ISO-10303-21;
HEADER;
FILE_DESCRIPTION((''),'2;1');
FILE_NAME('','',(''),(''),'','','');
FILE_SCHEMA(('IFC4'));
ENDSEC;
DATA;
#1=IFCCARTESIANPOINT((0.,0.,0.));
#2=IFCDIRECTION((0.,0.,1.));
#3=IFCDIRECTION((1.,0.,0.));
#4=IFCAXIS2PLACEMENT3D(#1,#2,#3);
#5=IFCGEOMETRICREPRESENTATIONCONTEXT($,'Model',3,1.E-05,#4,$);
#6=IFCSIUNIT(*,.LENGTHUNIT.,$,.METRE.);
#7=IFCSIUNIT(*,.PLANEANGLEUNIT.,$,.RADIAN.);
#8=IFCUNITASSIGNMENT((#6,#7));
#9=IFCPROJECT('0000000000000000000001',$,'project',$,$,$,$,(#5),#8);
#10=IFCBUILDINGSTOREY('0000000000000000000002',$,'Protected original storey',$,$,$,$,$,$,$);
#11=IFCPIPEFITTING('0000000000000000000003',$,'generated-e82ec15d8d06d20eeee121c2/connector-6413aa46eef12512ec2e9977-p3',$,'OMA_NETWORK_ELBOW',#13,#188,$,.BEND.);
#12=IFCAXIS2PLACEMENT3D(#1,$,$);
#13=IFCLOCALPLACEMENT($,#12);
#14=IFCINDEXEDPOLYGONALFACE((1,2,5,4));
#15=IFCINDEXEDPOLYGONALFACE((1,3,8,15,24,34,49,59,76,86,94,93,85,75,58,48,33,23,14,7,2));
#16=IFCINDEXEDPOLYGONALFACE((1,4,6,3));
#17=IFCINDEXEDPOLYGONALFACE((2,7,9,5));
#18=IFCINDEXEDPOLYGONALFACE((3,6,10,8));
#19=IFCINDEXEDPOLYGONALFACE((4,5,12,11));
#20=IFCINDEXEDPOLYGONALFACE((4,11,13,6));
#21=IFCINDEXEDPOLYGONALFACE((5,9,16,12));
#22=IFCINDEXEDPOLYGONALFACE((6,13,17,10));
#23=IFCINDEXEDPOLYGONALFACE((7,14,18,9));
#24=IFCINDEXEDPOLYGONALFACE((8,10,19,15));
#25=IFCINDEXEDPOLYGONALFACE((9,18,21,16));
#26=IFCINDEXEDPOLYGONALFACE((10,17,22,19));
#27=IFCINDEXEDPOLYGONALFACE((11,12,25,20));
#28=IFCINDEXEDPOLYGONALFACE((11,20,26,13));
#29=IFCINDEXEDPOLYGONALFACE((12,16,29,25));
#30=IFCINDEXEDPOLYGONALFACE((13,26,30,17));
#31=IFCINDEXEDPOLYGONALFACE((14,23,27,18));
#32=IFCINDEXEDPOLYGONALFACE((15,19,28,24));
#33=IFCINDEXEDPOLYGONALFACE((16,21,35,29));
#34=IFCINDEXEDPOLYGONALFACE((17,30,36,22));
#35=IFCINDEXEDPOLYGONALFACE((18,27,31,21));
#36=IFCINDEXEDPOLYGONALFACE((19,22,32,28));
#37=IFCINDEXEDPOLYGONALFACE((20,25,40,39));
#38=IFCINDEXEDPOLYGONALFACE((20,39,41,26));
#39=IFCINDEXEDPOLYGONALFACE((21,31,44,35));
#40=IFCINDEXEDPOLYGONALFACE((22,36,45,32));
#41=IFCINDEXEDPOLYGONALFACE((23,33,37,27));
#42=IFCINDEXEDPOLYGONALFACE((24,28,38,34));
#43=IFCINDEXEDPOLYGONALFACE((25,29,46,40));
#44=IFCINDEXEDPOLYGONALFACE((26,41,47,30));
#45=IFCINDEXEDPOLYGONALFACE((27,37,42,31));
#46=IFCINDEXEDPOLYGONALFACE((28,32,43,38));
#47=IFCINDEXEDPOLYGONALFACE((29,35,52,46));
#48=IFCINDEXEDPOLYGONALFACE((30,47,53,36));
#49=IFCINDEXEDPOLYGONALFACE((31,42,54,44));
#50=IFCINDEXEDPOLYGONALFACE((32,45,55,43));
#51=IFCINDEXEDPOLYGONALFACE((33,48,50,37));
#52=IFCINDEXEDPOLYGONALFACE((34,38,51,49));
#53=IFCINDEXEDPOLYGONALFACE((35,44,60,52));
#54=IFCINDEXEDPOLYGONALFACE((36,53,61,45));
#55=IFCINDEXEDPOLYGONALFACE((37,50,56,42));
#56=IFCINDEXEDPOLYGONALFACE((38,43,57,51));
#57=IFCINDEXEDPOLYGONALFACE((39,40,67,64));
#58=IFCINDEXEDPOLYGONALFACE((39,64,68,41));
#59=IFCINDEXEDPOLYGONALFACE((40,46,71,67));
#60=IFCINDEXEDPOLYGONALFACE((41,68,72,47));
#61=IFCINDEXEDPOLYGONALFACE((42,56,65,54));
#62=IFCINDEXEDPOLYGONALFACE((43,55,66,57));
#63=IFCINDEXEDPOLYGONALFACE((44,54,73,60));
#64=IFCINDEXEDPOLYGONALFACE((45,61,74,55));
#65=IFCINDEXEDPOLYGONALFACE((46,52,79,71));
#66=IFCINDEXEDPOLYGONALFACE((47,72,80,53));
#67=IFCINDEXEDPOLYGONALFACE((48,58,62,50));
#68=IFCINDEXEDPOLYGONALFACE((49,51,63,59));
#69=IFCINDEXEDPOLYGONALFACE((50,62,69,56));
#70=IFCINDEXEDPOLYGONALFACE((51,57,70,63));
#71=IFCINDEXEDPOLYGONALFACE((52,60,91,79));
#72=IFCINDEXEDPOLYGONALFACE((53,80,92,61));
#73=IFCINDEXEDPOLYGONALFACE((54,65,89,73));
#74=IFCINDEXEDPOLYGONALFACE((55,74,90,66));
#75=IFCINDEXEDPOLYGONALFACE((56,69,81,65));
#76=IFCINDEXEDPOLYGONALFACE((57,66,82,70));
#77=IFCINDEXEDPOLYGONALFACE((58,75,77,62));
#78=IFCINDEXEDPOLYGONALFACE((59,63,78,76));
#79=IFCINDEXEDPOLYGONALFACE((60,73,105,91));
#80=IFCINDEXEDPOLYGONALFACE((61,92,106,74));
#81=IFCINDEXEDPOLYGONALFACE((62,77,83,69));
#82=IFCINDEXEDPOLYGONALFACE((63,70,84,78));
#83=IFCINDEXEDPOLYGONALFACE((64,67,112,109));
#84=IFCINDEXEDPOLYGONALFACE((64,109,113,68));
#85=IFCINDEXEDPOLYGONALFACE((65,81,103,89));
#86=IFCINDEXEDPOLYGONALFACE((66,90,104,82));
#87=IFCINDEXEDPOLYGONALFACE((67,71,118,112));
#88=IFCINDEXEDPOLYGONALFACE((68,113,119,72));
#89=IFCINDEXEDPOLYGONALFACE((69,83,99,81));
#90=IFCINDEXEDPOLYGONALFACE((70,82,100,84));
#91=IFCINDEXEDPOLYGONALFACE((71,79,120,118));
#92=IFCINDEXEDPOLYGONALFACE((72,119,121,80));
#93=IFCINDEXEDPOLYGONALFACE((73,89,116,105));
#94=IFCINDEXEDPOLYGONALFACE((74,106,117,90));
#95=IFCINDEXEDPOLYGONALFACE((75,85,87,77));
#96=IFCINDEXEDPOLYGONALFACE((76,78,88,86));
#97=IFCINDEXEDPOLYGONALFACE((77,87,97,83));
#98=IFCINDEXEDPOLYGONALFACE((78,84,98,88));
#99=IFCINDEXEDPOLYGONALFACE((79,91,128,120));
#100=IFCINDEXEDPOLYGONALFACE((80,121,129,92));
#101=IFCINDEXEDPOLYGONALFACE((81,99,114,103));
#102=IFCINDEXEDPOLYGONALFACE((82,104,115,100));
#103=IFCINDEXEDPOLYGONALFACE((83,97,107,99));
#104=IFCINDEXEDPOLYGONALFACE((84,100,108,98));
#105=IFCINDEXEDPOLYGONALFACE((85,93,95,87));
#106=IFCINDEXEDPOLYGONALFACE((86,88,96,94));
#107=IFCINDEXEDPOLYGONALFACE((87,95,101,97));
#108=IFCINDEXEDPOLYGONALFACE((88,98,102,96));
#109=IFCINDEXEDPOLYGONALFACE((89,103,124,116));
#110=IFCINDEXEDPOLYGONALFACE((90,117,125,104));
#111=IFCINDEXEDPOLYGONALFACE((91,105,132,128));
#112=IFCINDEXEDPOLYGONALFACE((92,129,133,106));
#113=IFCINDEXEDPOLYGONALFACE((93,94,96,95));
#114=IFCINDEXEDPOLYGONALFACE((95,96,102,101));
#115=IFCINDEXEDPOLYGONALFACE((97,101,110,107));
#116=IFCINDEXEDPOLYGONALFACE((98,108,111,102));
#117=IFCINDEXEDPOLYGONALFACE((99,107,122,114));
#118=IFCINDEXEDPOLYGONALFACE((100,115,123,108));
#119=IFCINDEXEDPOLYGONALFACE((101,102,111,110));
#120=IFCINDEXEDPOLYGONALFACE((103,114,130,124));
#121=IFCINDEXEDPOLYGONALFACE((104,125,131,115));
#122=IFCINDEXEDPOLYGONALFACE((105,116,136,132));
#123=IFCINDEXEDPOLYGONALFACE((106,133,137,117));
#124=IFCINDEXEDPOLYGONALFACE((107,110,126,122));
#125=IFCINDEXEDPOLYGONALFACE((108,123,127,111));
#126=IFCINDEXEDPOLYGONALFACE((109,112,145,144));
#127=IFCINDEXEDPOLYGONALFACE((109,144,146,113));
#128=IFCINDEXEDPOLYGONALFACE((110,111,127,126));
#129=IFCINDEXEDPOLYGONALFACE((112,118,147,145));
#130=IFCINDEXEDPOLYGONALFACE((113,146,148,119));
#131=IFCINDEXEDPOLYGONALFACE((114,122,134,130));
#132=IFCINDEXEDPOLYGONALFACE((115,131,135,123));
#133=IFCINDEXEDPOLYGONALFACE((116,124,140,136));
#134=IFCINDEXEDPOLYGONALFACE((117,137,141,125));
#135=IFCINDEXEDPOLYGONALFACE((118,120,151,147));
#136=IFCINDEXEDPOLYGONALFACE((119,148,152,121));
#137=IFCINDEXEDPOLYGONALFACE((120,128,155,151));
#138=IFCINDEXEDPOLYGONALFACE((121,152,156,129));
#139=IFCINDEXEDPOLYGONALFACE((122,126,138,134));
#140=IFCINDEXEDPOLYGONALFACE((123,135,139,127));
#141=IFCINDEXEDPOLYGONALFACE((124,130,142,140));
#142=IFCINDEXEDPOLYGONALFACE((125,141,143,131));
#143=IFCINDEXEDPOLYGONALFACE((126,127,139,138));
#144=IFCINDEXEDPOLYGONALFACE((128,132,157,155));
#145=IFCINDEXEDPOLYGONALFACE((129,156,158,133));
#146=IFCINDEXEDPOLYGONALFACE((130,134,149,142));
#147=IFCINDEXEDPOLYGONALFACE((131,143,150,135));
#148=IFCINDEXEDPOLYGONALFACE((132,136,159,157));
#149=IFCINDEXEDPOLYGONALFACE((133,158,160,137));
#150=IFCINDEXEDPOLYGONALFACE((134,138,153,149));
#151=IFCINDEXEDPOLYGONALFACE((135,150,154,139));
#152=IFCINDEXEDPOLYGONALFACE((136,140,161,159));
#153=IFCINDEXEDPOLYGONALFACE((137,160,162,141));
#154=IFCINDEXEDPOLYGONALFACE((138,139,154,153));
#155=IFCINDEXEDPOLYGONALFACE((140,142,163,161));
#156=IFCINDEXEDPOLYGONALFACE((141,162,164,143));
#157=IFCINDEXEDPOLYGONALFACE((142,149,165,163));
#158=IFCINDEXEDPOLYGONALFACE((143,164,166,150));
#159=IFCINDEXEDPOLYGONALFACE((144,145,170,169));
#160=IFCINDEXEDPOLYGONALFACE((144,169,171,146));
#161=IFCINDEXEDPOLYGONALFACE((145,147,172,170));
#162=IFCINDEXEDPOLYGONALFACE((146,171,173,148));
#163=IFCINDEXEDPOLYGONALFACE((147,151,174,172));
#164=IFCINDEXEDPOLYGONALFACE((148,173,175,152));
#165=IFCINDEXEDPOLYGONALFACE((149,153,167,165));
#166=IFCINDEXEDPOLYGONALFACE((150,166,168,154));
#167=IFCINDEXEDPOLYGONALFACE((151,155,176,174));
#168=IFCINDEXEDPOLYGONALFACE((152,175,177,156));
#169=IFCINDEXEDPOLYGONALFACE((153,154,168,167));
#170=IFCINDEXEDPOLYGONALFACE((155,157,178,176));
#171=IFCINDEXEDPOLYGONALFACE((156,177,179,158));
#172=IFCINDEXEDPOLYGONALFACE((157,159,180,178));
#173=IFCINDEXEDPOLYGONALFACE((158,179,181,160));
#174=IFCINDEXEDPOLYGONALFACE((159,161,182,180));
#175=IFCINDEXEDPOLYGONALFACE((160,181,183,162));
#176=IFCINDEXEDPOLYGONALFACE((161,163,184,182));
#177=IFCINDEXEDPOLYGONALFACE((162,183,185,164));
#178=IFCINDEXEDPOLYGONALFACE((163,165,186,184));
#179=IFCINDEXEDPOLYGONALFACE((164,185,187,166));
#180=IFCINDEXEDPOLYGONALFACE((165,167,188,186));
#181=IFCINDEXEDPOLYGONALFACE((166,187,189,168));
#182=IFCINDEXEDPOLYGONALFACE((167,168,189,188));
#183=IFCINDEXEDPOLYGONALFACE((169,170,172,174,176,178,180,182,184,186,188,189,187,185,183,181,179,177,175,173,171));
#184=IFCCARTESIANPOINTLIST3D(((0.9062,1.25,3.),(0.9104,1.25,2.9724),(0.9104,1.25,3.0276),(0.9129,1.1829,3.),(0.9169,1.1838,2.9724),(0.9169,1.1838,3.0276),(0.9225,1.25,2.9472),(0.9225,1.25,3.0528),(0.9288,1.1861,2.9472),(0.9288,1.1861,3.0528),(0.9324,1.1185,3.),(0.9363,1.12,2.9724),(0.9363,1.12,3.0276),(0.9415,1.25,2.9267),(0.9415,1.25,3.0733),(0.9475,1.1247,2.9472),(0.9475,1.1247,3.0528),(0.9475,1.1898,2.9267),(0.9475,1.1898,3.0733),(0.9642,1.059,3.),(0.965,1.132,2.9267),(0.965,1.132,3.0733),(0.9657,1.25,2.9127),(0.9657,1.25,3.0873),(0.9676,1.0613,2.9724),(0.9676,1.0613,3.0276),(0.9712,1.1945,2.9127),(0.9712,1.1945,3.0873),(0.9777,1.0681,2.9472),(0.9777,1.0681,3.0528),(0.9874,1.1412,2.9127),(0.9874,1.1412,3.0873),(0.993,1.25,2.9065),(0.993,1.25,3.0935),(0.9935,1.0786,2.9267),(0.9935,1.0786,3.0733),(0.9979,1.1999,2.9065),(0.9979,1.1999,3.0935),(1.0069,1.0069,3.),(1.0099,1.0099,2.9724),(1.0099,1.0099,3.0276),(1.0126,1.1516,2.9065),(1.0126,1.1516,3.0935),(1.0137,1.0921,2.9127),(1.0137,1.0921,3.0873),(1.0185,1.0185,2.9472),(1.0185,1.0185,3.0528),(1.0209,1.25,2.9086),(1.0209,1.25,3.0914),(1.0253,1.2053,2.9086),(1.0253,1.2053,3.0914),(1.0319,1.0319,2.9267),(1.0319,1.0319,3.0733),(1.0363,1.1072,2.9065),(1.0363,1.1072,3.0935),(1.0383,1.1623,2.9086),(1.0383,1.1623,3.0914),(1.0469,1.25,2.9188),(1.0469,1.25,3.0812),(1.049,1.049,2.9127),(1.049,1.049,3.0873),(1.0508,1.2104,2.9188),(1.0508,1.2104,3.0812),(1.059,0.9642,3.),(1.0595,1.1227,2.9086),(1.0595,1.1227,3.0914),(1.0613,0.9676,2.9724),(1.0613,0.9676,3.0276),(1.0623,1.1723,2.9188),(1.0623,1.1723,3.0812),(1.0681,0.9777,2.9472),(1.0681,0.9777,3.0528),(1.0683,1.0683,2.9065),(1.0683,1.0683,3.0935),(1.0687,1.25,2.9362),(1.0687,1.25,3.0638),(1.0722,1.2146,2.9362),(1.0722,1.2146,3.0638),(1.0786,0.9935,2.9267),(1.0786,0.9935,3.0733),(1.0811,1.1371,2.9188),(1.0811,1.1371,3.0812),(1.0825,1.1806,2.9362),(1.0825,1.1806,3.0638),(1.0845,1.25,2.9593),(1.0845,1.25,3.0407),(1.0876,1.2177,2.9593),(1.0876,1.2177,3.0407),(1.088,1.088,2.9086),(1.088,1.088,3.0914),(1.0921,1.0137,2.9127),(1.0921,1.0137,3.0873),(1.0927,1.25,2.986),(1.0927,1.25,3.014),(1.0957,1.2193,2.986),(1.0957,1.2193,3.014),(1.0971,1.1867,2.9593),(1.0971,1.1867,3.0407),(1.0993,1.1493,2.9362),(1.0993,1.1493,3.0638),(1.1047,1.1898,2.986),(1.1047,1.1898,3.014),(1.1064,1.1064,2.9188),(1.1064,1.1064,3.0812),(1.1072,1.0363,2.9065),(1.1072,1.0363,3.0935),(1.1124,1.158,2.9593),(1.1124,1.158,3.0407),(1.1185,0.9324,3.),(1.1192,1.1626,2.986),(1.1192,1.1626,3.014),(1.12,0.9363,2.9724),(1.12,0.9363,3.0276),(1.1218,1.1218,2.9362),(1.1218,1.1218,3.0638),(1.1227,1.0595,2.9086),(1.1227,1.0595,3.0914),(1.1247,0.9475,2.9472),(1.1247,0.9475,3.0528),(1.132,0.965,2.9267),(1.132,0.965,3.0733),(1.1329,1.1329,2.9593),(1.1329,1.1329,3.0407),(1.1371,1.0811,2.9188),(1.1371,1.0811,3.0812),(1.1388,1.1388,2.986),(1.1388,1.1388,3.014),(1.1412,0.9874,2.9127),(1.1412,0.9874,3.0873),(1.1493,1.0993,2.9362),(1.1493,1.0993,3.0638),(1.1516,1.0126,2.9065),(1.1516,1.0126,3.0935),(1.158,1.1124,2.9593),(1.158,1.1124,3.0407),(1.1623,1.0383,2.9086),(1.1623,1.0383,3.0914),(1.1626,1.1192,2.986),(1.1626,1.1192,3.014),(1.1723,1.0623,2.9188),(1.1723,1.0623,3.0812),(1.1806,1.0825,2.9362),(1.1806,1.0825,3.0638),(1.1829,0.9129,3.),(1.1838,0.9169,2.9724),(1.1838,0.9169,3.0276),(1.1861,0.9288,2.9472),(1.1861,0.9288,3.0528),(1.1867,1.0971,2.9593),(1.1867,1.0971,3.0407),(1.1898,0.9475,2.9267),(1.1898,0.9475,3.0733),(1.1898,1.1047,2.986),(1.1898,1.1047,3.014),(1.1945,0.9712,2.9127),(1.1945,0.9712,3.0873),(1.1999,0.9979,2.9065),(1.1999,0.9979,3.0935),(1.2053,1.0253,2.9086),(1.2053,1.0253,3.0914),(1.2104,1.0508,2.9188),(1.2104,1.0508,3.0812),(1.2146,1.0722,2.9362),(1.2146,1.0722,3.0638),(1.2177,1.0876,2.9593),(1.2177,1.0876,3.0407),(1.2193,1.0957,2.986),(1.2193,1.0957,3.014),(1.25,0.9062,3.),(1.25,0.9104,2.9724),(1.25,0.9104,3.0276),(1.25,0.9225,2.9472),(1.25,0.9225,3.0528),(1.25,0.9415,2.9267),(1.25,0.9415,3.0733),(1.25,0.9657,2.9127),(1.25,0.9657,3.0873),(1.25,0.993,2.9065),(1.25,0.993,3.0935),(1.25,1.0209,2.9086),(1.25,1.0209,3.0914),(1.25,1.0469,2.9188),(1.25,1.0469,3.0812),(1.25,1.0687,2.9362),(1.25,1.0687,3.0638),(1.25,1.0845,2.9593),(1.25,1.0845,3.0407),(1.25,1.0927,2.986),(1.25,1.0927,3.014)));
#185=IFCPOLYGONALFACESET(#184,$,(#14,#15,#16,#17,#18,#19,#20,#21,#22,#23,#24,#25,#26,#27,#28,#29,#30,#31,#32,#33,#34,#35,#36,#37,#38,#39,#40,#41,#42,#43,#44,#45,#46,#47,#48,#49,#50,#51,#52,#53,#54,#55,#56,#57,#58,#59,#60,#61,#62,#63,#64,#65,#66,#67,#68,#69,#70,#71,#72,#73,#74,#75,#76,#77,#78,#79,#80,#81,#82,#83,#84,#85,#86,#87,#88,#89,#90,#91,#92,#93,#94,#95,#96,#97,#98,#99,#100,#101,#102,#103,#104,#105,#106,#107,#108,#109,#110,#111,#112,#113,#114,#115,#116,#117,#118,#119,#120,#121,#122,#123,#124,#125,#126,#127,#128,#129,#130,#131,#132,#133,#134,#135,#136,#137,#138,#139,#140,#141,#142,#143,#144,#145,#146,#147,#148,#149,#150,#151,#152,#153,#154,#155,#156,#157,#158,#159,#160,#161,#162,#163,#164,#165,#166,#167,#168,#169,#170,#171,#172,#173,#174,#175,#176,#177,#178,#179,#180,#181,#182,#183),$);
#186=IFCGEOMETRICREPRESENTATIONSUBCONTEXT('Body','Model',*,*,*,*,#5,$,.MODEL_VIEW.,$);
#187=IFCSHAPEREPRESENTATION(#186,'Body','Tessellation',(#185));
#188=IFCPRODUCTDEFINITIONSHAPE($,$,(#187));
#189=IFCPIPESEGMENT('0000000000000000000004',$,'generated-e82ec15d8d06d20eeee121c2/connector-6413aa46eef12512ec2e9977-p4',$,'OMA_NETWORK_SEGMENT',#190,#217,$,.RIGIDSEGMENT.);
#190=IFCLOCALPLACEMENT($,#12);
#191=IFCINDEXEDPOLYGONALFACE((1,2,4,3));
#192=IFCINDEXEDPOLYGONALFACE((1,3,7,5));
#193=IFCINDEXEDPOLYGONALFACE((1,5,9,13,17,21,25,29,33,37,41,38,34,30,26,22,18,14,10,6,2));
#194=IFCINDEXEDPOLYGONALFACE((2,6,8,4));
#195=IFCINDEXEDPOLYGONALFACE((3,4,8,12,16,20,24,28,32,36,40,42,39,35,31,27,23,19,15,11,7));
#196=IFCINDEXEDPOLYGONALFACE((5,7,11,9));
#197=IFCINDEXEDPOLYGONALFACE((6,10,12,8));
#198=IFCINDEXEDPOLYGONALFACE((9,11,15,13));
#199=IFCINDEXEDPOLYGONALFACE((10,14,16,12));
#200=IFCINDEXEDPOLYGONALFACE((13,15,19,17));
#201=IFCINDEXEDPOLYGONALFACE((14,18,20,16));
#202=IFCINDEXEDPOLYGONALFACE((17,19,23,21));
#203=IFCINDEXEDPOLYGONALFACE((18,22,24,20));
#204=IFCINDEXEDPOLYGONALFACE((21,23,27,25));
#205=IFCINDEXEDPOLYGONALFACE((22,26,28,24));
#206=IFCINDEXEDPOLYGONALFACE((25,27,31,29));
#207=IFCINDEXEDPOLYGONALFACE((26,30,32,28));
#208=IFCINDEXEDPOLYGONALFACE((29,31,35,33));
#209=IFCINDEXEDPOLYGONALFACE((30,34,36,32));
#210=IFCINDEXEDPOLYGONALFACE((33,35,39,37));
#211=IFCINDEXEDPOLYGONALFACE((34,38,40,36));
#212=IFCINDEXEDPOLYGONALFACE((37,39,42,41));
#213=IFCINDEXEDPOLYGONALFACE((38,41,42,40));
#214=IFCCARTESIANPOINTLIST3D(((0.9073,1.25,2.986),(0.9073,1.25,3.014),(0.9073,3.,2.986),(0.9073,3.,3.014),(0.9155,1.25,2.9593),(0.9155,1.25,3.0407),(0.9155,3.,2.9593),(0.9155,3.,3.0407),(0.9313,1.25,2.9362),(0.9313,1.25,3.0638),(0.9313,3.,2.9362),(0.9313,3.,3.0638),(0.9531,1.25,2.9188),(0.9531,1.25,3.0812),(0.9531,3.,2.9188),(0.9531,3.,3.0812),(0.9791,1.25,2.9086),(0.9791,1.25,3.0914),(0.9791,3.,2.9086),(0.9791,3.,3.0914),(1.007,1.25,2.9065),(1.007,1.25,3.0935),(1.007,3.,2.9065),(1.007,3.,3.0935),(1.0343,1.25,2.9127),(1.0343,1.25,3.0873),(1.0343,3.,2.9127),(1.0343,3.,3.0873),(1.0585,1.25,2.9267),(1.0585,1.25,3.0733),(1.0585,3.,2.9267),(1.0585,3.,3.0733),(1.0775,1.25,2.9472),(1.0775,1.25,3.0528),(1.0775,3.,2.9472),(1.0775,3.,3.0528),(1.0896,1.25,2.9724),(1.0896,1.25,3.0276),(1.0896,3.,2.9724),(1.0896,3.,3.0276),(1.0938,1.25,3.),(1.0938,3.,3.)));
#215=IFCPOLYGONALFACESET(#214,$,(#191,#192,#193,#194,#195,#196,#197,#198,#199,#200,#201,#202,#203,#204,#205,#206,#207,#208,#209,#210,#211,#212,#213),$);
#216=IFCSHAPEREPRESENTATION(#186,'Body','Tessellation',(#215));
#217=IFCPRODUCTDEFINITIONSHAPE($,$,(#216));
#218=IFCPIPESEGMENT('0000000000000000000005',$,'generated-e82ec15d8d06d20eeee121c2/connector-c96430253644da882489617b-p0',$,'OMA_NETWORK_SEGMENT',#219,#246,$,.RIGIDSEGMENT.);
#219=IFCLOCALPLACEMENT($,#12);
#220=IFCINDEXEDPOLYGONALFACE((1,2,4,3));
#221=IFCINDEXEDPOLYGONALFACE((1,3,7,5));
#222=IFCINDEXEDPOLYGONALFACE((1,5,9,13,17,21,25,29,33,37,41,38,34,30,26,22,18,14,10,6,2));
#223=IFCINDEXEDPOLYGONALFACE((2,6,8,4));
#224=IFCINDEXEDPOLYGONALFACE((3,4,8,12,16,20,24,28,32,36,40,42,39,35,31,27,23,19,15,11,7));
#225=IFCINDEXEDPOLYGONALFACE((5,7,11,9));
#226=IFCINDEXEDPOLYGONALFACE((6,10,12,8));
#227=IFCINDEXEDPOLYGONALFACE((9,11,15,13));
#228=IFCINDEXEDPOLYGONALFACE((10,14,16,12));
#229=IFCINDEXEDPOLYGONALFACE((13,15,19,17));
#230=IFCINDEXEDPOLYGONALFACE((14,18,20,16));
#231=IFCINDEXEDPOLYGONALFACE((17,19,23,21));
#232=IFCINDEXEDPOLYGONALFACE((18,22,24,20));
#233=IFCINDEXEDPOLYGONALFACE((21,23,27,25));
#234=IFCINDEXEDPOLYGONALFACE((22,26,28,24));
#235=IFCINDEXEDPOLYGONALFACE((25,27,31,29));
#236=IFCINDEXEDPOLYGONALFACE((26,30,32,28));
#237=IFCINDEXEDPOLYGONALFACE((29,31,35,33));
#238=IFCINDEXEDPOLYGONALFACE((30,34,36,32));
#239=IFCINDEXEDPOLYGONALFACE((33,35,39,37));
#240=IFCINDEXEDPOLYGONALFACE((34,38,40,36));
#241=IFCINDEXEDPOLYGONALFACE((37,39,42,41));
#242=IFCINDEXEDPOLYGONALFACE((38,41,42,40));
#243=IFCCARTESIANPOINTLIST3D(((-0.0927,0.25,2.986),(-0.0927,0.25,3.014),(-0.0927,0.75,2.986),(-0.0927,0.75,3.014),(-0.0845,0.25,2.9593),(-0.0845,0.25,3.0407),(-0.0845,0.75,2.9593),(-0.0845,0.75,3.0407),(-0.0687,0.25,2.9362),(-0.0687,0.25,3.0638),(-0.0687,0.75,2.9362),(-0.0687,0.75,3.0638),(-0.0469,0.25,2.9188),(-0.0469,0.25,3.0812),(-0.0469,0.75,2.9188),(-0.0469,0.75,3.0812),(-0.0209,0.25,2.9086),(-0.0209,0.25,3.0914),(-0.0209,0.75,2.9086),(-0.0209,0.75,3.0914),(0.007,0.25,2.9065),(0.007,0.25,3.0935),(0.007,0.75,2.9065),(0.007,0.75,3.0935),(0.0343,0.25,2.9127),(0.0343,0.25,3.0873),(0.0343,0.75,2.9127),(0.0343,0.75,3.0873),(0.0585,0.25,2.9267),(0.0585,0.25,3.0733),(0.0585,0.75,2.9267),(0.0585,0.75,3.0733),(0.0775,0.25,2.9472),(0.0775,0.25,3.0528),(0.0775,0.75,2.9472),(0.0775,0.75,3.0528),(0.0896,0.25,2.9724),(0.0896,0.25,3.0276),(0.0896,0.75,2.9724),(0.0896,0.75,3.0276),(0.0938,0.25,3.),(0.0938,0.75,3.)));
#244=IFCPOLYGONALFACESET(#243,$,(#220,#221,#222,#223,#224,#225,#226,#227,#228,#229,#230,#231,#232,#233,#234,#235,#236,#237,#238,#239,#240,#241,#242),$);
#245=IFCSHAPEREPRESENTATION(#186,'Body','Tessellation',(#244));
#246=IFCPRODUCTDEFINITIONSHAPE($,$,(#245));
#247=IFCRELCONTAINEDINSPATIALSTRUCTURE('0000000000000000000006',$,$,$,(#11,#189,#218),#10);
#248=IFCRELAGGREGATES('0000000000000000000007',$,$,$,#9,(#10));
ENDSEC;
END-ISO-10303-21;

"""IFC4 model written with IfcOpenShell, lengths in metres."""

from ifc_helpers import new_model, entity, si_unit, frame, origin_with_axes, origin_2d, place, context, subcontext, project, spatial, circle, extrude, element, save


model = new_model("IFC4")

# Units and contexts
model_context = context("Model", 3, precision=1e-05, world=origin_with_axes())
body_context = subcontext(model_context, "Body", "Model", "MODEL_VIEW")
ifc_project = project(units=[si_unit("LENGTHUNIT", "METRE"), si_unit("PLANEANGLEUNIT", "RADIAN")], contexts=[model_context])

# Storey
storey = spatial("IfcBuildingStorey", under=ifc_project, Name="Protected original storey")

# Pipe fitting
pipe_fitting_1_placement = place(None, origin_with_axes())
element("IfcPipeFitting", 1, at=pipe_fitting_1_placement, inside=storey, Name="generated-e82ec15d8d06d20eeee121c2/connector-6413aa46eef12512ec2e9977-p3", ObjectType="OMA_NETWORK_ELBOW", PredefinedType="BEND", context=body_context, shape_type="SweptSolid", body=[
    entity("IfcRevolvedAreaSolid", entity("IfcCircleProfileDef", "AREA", None, entity("IfcAxis2Placement2D", entity("IfcCartesianPoint", [0.25, 0.0])), 0.0938), entity("IfcAxis2Placement3D", entity("IfcCartesianPoint", [1.25, 1.25, 3.0]), entity("IfcDirection", [-1.0, 0.0, 0.0]), entity("IfcDirection", [0.0, -1.0, 0.0])), entity("IfcAxis1Placement", entity("IfcCartesianPoint", [0.0, 0.0, 0.0]), entity("IfcDirection", [0.0, -1.0, 0.0])), 1.570796),
])

# Pipe segments
pipe_segment_1_placement = place(None, origin_with_axes())
element("IfcPipeSegment", 2, at=pipe_segment_1_placement, inside=storey, Name="generated-e82ec15d8d06d20eeee121c2/connector-6413aa46eef12512ec2e9977-p4", ObjectType="OMA_NETWORK_SEGMENT", PredefinedType="RIGIDSEGMENT", context=body_context, shape_type="SweptSolid", body=[
    extrude(circle(Radius=0.0938, at=origin_2d()), frame((1.0, 1.25, 3.0), z_axis=(0.0, 1.0, 0.0), x_axis=(1.0, 0.0, 0.0)), (0.0, 0.0, 1.0), 1.75),
])
pipe_segment_2_placement = place(None, origin_with_axes())
element("IfcPipeSegment", 3, at=pipe_segment_2_placement, inside=storey, Name="generated-e82ec15d8d06d20eeee121c2/connector-c96430253644da882489617b-p0", ObjectType="OMA_NETWORK_SEGMENT", PredefinedType="RIGIDSEGMENT", context=body_context, shape_type="SweptSolid", body=[
    extrude(circle(Radius=0.0938, at=origin_2d()), frame((0.0, 0.25, 3.0), z_axis=(0.0, 1.0, 0.0), x_axis=(1.0, 0.0, 0.0)), (0.0, 0.0, 1.0), 0.5),
])

save(model, "model.ifc")
